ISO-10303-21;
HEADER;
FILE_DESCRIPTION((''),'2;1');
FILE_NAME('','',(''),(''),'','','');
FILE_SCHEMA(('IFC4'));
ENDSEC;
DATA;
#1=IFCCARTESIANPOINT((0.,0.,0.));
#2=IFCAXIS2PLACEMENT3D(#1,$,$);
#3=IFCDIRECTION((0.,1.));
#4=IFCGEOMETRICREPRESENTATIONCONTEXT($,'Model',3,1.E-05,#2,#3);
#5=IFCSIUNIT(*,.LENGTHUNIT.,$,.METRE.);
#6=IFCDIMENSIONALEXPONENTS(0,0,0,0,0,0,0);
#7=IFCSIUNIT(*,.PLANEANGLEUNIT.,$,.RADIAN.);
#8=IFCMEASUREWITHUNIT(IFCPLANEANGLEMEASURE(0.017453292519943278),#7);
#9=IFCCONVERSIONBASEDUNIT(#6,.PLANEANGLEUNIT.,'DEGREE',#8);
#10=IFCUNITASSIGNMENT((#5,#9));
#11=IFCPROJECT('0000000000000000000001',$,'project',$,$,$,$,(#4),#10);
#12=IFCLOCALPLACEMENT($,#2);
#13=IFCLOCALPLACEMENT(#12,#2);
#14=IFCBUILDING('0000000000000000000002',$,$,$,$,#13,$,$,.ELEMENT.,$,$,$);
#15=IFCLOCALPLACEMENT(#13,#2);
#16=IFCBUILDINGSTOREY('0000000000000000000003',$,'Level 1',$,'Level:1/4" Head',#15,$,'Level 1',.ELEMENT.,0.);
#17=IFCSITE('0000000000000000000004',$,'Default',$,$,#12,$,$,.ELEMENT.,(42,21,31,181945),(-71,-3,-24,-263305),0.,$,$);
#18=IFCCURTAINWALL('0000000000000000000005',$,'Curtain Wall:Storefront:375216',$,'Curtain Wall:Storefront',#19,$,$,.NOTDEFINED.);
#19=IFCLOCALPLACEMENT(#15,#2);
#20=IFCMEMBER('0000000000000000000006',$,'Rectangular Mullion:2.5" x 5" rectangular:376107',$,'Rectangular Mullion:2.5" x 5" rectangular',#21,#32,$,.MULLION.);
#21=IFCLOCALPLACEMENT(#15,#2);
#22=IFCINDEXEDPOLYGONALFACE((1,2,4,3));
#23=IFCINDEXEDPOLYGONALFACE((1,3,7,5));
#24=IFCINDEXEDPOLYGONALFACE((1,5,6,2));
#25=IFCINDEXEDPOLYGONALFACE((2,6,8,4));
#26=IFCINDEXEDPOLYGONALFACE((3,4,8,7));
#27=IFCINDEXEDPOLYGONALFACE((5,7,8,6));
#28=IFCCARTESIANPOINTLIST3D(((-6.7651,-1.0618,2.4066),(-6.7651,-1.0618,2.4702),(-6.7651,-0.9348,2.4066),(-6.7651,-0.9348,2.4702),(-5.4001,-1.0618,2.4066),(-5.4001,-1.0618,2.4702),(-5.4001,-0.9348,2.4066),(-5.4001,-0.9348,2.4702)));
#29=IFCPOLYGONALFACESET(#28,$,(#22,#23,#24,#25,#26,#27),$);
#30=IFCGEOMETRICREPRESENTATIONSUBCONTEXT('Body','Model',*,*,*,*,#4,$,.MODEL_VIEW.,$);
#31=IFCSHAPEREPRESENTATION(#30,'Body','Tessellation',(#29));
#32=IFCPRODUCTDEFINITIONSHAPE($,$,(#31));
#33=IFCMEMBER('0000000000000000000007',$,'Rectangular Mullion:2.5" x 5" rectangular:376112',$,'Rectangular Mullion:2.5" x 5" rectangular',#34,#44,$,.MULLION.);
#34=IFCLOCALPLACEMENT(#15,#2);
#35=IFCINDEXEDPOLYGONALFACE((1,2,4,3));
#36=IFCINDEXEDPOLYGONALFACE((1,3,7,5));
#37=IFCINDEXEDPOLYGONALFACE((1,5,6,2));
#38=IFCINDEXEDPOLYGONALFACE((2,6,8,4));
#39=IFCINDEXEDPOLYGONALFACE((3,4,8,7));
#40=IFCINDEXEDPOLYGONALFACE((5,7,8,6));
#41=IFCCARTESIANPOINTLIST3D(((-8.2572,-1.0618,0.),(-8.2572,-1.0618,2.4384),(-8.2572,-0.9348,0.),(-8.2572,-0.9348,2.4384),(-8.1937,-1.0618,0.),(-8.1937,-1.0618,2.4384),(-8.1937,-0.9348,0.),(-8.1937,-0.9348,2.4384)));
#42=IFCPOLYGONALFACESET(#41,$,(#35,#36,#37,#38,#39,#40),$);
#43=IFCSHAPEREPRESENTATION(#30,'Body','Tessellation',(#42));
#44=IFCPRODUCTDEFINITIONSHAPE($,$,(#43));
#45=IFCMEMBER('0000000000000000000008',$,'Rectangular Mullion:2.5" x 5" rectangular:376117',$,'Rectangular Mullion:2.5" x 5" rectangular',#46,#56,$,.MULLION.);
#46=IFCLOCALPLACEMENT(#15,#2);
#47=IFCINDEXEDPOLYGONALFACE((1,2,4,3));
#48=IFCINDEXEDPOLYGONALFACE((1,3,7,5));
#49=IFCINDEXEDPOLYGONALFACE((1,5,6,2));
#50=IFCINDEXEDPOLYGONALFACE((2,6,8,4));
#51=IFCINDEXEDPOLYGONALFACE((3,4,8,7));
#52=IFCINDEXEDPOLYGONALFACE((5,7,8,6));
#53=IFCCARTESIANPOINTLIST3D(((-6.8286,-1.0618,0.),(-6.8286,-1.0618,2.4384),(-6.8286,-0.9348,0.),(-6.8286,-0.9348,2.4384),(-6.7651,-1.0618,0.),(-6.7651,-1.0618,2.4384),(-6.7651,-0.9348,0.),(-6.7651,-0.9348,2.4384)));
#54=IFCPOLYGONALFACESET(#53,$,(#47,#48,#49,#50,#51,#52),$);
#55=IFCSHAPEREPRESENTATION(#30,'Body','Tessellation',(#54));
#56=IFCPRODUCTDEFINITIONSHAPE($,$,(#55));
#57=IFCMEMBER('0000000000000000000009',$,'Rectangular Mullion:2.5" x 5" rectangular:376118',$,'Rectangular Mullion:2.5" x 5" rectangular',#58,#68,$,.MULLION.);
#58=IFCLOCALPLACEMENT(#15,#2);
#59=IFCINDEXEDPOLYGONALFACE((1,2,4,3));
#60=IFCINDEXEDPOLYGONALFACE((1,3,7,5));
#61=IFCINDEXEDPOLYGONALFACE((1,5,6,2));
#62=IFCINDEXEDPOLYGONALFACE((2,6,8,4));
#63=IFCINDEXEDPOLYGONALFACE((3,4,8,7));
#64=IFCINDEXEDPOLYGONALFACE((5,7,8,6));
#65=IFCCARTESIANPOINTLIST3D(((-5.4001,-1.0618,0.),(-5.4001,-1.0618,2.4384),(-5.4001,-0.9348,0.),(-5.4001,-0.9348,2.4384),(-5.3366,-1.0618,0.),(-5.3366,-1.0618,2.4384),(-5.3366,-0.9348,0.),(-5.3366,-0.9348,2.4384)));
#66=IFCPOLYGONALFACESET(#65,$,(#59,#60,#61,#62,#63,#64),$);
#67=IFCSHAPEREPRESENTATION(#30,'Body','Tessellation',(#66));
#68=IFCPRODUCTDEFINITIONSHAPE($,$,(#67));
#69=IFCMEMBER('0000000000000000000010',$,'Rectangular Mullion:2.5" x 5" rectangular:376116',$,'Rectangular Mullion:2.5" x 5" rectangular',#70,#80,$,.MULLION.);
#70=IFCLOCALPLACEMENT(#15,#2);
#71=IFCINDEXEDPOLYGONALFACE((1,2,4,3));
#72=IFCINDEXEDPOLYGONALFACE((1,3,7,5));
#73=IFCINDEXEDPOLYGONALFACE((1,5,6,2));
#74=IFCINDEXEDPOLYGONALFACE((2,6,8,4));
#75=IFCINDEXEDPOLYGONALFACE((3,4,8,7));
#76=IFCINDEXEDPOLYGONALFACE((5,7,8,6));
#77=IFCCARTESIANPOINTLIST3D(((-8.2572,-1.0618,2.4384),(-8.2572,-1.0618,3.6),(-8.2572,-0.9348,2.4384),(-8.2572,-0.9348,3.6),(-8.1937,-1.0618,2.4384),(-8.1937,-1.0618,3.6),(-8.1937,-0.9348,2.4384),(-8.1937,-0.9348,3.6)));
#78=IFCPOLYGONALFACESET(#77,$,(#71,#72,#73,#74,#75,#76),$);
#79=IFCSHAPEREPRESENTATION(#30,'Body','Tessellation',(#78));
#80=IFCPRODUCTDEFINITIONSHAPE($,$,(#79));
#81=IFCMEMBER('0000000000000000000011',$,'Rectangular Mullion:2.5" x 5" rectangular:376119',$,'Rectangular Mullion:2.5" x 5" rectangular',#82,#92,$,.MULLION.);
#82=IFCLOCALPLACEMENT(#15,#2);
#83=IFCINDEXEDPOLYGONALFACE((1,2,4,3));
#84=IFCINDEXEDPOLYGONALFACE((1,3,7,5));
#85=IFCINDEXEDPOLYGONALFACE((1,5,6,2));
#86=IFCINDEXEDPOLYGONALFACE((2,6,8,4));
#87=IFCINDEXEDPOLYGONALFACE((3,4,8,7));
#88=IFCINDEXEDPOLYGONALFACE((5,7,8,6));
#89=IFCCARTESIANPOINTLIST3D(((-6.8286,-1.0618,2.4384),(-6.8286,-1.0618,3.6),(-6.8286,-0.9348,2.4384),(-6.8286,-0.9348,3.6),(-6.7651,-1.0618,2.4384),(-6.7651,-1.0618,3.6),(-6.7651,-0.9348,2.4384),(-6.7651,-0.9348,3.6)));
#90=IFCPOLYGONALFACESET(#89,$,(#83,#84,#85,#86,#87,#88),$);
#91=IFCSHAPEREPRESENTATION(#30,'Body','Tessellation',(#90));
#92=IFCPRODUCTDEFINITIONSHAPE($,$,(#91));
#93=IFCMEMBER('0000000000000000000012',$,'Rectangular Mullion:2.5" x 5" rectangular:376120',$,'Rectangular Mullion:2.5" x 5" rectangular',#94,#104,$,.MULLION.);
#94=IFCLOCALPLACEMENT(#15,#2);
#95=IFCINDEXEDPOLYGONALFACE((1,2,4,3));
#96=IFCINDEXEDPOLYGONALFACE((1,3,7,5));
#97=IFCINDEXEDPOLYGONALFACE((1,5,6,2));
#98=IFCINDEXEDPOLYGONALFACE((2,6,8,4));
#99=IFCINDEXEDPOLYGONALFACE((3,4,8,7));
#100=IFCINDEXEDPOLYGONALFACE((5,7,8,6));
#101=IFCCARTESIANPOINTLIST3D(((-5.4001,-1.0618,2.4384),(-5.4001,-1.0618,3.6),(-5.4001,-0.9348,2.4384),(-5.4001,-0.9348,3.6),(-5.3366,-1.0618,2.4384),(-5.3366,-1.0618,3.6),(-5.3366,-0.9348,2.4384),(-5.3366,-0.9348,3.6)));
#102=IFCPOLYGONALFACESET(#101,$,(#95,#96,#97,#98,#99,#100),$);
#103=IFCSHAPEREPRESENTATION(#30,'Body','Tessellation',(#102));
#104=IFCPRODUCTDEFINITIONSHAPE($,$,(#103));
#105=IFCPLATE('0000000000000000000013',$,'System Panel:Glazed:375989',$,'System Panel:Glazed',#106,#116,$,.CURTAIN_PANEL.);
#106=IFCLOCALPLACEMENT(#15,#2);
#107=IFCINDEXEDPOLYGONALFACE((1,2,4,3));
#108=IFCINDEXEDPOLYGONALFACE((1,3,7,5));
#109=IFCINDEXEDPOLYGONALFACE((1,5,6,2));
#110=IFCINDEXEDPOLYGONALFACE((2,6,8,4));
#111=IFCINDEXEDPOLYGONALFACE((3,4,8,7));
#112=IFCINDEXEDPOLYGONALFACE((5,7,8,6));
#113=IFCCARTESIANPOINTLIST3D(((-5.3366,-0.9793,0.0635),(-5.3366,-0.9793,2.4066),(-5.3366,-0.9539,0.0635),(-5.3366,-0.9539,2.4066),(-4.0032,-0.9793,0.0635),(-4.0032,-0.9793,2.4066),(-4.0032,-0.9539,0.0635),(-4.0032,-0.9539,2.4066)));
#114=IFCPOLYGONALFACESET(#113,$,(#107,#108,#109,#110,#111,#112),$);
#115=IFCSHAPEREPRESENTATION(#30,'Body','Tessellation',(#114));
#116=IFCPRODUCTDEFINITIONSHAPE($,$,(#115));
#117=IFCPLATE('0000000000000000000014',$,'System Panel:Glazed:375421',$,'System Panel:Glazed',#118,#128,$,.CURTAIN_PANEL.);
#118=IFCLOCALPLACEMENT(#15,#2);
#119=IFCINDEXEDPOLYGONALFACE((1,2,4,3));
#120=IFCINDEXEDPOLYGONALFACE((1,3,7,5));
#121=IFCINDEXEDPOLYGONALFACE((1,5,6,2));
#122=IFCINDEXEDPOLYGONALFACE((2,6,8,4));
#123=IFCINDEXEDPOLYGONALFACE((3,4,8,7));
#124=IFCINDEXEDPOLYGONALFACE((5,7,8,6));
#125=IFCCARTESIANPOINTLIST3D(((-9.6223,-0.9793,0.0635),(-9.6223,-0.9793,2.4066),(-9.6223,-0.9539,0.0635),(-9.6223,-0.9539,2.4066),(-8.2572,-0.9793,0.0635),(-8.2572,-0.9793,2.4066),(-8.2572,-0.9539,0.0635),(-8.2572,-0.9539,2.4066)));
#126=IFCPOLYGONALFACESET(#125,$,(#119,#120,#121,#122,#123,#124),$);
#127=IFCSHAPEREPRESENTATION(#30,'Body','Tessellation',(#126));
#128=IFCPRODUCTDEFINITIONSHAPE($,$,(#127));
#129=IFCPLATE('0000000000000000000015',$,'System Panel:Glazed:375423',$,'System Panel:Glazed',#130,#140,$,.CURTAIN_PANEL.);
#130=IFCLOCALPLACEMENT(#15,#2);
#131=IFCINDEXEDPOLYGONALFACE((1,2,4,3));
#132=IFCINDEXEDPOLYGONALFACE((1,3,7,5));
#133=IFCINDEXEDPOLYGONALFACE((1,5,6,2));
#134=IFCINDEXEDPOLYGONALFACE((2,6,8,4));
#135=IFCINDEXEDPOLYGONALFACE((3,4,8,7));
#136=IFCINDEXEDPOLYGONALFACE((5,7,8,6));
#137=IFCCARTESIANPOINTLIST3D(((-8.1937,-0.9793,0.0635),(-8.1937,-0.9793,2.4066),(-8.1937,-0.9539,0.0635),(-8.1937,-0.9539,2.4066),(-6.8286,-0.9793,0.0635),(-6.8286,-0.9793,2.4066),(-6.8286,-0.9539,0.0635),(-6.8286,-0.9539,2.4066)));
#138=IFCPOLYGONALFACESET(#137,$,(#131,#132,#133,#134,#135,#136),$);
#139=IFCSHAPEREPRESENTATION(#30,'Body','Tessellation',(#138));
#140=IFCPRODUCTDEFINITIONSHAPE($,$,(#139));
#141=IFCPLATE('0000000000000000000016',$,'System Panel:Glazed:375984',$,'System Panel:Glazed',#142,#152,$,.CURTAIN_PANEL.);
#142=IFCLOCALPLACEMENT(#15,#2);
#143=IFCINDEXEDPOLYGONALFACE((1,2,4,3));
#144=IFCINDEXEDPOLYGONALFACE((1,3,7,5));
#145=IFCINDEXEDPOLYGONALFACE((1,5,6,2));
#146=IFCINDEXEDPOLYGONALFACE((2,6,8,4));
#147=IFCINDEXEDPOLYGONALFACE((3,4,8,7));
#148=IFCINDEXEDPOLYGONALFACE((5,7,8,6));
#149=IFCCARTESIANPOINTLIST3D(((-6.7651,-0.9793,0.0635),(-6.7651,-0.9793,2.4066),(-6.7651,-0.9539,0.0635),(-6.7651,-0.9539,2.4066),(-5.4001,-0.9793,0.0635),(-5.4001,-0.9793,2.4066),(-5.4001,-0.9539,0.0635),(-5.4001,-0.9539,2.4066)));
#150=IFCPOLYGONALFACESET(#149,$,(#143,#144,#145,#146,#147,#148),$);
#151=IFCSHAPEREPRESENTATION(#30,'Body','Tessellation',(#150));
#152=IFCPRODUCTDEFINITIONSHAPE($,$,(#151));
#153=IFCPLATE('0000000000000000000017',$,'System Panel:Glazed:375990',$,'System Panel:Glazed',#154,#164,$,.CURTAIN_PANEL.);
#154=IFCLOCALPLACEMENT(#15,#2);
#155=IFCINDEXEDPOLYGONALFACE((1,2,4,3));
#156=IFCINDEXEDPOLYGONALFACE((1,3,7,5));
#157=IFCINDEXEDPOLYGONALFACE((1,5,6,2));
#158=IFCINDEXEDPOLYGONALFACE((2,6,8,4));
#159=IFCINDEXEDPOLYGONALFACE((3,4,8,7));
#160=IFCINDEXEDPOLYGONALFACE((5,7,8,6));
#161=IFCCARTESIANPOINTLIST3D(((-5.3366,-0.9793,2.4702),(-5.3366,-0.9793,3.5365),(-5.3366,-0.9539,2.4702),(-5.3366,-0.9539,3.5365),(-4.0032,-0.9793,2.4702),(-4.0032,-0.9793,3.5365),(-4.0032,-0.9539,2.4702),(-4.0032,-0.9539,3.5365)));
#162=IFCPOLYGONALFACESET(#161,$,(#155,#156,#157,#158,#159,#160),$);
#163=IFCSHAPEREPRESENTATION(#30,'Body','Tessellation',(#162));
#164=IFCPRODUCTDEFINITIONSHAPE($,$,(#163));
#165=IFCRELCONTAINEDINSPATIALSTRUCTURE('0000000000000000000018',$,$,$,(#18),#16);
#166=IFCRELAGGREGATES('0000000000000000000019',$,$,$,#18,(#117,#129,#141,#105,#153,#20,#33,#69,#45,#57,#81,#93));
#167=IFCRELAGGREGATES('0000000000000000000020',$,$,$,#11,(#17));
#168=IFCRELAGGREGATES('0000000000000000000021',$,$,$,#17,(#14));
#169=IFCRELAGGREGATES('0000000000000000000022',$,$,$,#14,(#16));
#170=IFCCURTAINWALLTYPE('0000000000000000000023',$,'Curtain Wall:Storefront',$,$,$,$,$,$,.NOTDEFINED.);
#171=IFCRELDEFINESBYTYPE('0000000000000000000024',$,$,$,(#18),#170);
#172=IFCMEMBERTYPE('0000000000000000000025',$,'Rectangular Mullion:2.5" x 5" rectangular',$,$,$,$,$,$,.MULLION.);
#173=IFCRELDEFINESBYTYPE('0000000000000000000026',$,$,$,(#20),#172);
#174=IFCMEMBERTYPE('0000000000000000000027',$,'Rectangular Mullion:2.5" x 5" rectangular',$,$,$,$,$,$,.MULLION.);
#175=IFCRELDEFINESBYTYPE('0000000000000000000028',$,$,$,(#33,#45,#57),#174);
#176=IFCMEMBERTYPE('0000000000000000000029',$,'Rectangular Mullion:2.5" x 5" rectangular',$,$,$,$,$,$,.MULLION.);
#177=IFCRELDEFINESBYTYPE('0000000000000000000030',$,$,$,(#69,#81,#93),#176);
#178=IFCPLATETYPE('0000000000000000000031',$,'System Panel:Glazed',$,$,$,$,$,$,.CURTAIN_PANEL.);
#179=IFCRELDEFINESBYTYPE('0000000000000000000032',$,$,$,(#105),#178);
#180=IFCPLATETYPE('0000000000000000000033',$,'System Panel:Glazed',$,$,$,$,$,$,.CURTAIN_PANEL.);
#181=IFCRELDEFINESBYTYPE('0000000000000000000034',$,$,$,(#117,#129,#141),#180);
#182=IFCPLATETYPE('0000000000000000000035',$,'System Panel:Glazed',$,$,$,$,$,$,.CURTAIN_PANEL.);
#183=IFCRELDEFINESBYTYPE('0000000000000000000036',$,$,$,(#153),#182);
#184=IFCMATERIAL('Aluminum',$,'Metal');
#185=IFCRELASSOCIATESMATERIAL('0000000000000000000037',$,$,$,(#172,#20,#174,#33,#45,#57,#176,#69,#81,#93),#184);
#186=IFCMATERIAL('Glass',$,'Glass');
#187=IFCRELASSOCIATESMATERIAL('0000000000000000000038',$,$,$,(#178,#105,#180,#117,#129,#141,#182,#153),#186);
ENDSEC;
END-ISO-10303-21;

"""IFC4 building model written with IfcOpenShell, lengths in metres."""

from ifc_helpers import new_model, entity, si_unit, converted_unit, direction, frame, origin, place, context, subcontext, project, spatial, indexed_curve, outline, extrude, source, transform, mapped, material, type_object, type_shapes, element, aggregate, save


model = new_model("IFC4")

# Units and contexts
model_context = context("Model", 3, precision=1e-05, world=origin(), true_north=direction((0.0, 1.0)))
body_context = subcontext(model_context, "Body", "Model", "MODEL_VIEW")
ifc_project = project(units=[si_unit("LENGTHUNIT", "METRE"), converted_unit("PLANEANGLEUNIT", "DEGREE", entity("IfcPlaneAngleMeasure", 0.017453292519943278), si_unit("PLANEANGLEUNIT", "RADIAN"), dimensions=[0, 0, 0, 0, 0, 0, 0])], contexts=[model_context])

# Site, building, storey
site_placement = place(None, origin())
site = spatial("IfcSite", under=ifc_project, at=site_placement, Name="Default", CompositionType="ELEMENT", RefLatitude=(42, 21, 31, 181945), RefLongitude=(-71, -3, -24, -263305), RefElevation=0.0)
building_placement = place(site_placement, origin())
building = spatial("IfcBuilding", under=site, at=building_placement, CompositionType="ELEMENT")
storey_placement = place(building_placement, origin())
storey = spatial("IfcBuildingStorey", under=building, at=storey_placement, Name="Level 1", ObjectType="Level:1/4\" Head", LongName="Level 1", CompositionType="ELEMENT", Elevation=0.0)

# Curtain wall, members, plates
curtain_wall_type = type_object("IfcCurtainWallType", Name="Curtain Wall:Storefront", PredefinedType="NOTDEFINED")
curtain_wall_placement = place(storey_placement, origin())
curtain_wall = element("IfcCurtainWall", 1, at=curtain_wall_placement, inside=storey, type_object=curtain_wall_type, Name="Curtain Wall:Storefront:375216", ObjectType="Curtain Wall:Storefront", PredefinedType="NOTDEFINED")
ifc_material_1 = material(Name="Aluminum", Category="Metal")
member_type_1 = type_object("IfcMemberType", Name="Rectangular Mullion:2.5\" x 5\" rectangular", PredefinedType="MULLION", material=ifc_material_1)
shared_shape_1 = source(origin(), body_context, "Body", "SweptSolid", [
    extrude(outline(indexed_curve([(-0.0318, -0.0635), (0.0318, -0.0635), (0.0318, 0.0635), (-0.0318, 0.0635), (-0.0318, -0.0635)], self_intersect=False)), frame((0.0, 0.0, -1.3651), z_axis=(0.0, 0.0, 1.0), x_axis=(-1.0, 0.0, 0.0)), (0.0, 0.0, 1.0), 1.3651),
])
type_shapes(member_type_1, [shared_shape_1])
member_1_placement = place(curtain_wall_placement, frame((-5.4001, -0.9983, 2.4384), z_axis=(1.0, 0.0, 0.0), x_axis=(0.0, 0.0, 1.0)))
member_1 = element("IfcMember", 2, at=member_1_placement, type_object=member_type_1, material=ifc_material_1, Name="Rectangular Mullion:2.5\" x 5\" rectangular:376107", ObjectType="Rectangular Mullion:2.5\" x 5\" rectangular", PredefinedType="MULLION", context=body_context, shape_type="MappedRepresentation", body=[
    mapped(shared_shape_1, transform((0.0, 0.0, 0.0), scale=1.0)),
])
member_type_2 = type_object("IfcMemberType", Name="Rectangular Mullion:2.5\" x 5\" rectangular", PredefinedType="MULLION", material=ifc_material_1)
shared_shape_2 = source(origin(), body_context, "Body", "SweptSolid", [
    extrude(outline(indexed_curve([(-0.0318, -0.0635), (0.0318, -0.0635), (0.0318, 0.0635), (-0.0318, 0.0635), (-0.0318, -0.0635)], self_intersect=False)), frame((0.0, 0.0, -2.4384), z_axis=(0.0, 0.0, 1.0), x_axis=(-1.0, 0.0, 0.0)), (0.0, 0.0, 1.0), 2.4384),
])
type_shapes(member_type_2, [shared_shape_2])
member_2_placement = place(curtain_wall_placement, frame((-8.2254, -0.9983, 0.0), z_axis=(0.0, 0.0, -1.0), x_axis=(1.0, 0.0, 0.0)))
member_2 = element("IfcMember", 3, at=member_2_placement, type_object=member_type_2, material=ifc_material_1, Name="Rectangular Mullion:2.5\" x 5\" rectangular:376112", ObjectType="Rectangular Mullion:2.5\" x 5\" rectangular", PredefinedType="MULLION", context=body_context, shape_type="MappedRepresentation", body=[
    mapped(shared_shape_2, transform((0.0, 0.0, 0.0), scale=1.0)),
])
member_3_placement = place(curtain_wall_placement, frame((-6.7969, -0.9983, 0.0), z_axis=(0.0, 0.0, -1.0), x_axis=(1.0, 0.0, 0.0)))
member_3 = element("IfcMember", 4, at=member_3_placement, type_object=member_type_2, material=ifc_material_1, Name="Rectangular Mullion:2.5\" x 5\" rectangular:376117", ObjectType="Rectangular Mullion:2.5\" x 5\" rectangular", PredefinedType="MULLION", context=body_context, shape_type="MappedRepresentation", body=[
    mapped(shared_shape_2, transform((0.0, 0.0, 0.0), scale=1.0)),
])
member_4_placement = place(curtain_wall_placement, frame((-5.3683, -0.9983, 0.0), z_axis=(0.0, 0.0, -1.0), x_axis=(1.0, 0.0, 0.0)))
member_4 = element("IfcMember", 5, at=member_4_placement, type_object=member_type_2, material=ifc_material_1, Name="Rectangular Mullion:2.5\" x 5\" rectangular:376118", ObjectType="Rectangular Mullion:2.5\" x 5\" rectangular", PredefinedType="MULLION", context=body_context, shape_type="MappedRepresentation", body=[
    mapped(shared_shape_2, transform((0.0, 0.0, 0.0), scale=1.0)),
])
member_type_3 = type_object("IfcMemberType", Name="Rectangular Mullion:2.5\" x 5\" rectangular", PredefinedType="MULLION", material=ifc_material_1)
shared_shape_3 = source(origin(), body_context, "Body", "SweptSolid", [
    extrude(outline(indexed_curve([(-0.0318, -0.0635), (0.0318, -0.0635), (0.0318, 0.0635), (-0.0318, 0.0635), (-0.0318, -0.0635)], self_intersect=False)), frame((0.0, 0.0, -1.1616), z_axis=(0.0, 0.0, 1.0), x_axis=(-1.0, 0.0, 0.0)), (0.0, 0.0, 1.0), 1.1616),
])
type_shapes(member_type_3, [shared_shape_3])
member_5_placement = place(curtain_wall_placement, frame((-8.2254, -0.9983, 2.4384), z_axis=(0.0, 0.0, -1.0), x_axis=(1.0, 0.0, 0.0)))
member_5 = element("IfcMember", 6, at=member_5_placement, type_object=member_type_3, material=ifc_material_1, Name="Rectangular Mullion:2.5\" x 5\" rectangular:376116", ObjectType="Rectangular Mullion:2.5\" x 5\" rectangular", PredefinedType="MULLION", context=body_context, shape_type="MappedRepresentation", body=[
    mapped(shared_shape_3, transform((0.0, 0.0, 0.0), scale=1.0)),
])
member_6_placement = place(curtain_wall_placement, frame((-6.7969, -0.9983, 2.4384), z_axis=(0.0, 0.0, -1.0), x_axis=(1.0, 0.0, 0.0)))
member_6 = element("IfcMember", 7, at=member_6_placement, type_object=member_type_3, material=ifc_material_1, Name="Rectangular Mullion:2.5\" x 5\" rectangular:376119", ObjectType="Rectangular Mullion:2.5\" x 5\" rectangular", PredefinedType="MULLION", context=body_context, shape_type="MappedRepresentation", body=[
    mapped(shared_shape_3, transform((0.0, 0.0, 0.0), scale=1.0)),
])
member_7_placement = place(curtain_wall_placement, frame((-5.3683, -0.9983, 2.4384), z_axis=(0.0, 0.0, -1.0), x_axis=(1.0, 0.0, 0.0)))
member_7 = element("IfcMember", 8, at=member_7_placement, type_object=member_type_3, material=ifc_material_1, Name="Rectangular Mullion:2.5\" x 5\" rectangular:376120", ObjectType="Rectangular Mullion:2.5\" x 5\" rectangular", PredefinedType="MULLION", context=body_context, shape_type="MappedRepresentation", body=[
    mapped(shared_shape_3, transform((0.0, 0.0, 0.0), scale=1.0)),
])
ifc_material_2 = material(Name="Glass", Category="Glass")
plate_type_1 = type_object("IfcPlateType", Name="System Panel:Glazed", PredefinedType="CURTAIN_PANEL", material=ifc_material_2)
shared_shape_4 = source(origin(), body_context, "Body", "SweptSolid", [
    extrude(outline(indexed_curve([(-0.0127, -0.6667), (0.0127, -0.6667), (0.0127, 0.6667), (-0.0127, 0.6667), (-0.0127, -0.6667)], self_intersect=False)), frame((0.0, 0.0318, 0.0), z_axis=(0.0, 0.0, 1.0), x_axis=(0.0, 1.0, 0.0)), (0.0, 0.0, 1.0), 2.3432),
])
type_shapes(plate_type_1, [shared_shape_4])
plate_1_placement = place(curtain_wall_placement, frame((-4.6699, -0.9983, 0.0635)))
plate_1 = element("IfcPlate", 9, at=plate_1_placement, type_object=plate_type_1, material=ifc_material_2, Name="System Panel:Glazed:375989", ObjectType="System Panel:Glazed", PredefinedType="CURTAIN_PANEL", context=body_context, shape_type="MappedRepresentation", body=[
    mapped(shared_shape_4, transform((0.0, 0.0, 0.0), scale=1.0)),
])
plate_type_2 = type_object("IfcPlateType", Name="System Panel:Glazed", PredefinedType="CURTAIN_PANEL", material=ifc_material_2)
shared_shape_5 = source(origin(), body_context, "Body", "SweptSolid", [
    extrude(outline(indexed_curve([(-0.0127, -0.6825), (0.0127, -0.6825), (0.0127, 0.6825), (-0.0127, 0.6825), (-0.0127, -0.6825)], self_intersect=False)), frame((0.0, 0.0318, 0.0), z_axis=(0.0, 0.0, 1.0), x_axis=(0.0, 1.0, 0.0)), (0.0, 0.0, 1.0), 2.3432),
])
type_shapes(plate_type_2, [shared_shape_5])
plate_2_placement = place(curtain_wall_placement, frame((-8.9397, -0.9983, 0.0635)))
plate_2 = element("IfcPlate", 10, at=plate_2_placement, type_object=plate_type_2, material=ifc_material_2, Name="System Panel:Glazed:375421", ObjectType="System Panel:Glazed", PredefinedType="CURTAIN_PANEL", context=body_context, shape_type="MappedRepresentation", body=[
    mapped(shared_shape_5, transform((0.0, 0.0, 0.0), scale=1.0)),
])
plate_3_placement = place(curtain_wall_placement, frame((-7.5112, -0.9983, 0.0635)))
plate_3 = element("IfcPlate", 11, at=plate_3_placement, type_object=plate_type_2, material=ifc_material_2, Name="System Panel:Glazed:375423", ObjectType="System Panel:Glazed", PredefinedType="CURTAIN_PANEL", context=body_context, shape_type="MappedRepresentation", body=[
    mapped(shared_shape_5, transform((0.0, 0.0, 0.0), scale=1.0)),
])
plate_4_placement = place(curtain_wall_placement, frame((-6.0826, -0.9983, 0.0635)))
plate_4 = element("IfcPlate", 12, at=plate_4_placement, type_object=plate_type_2, material=ifc_material_2, Name="System Panel:Glazed:375984", ObjectType="System Panel:Glazed", PredefinedType="CURTAIN_PANEL", context=body_context, shape_type="MappedRepresentation", body=[
    mapped(shared_shape_5, transform((0.0, 0.0, 0.0), scale=1.0)),
])
plate_type_3 = type_object("IfcPlateType", Name="System Panel:Glazed", PredefinedType="CURTAIN_PANEL", material=ifc_material_2)
shared_shape_6 = source(origin(), body_context, "Body", "SweptSolid", [
    extrude(outline(indexed_curve([(-0.0127, -0.6667), (0.0127, -0.6667), (0.0127, 0.6667), (-0.0127, 0.6667), (-0.0127, -0.6667)], self_intersect=False)), frame((0.0, 0.0318, 0.0), z_axis=(0.0, 0.0, 1.0), x_axis=(0.0, 1.0, 0.0)), (0.0, 0.0, 1.0), 1.0663),
])
type_shapes(plate_type_3, [shared_shape_6])
plate_5_placement = place(curtain_wall_placement, frame((-4.6699, -0.9983, 2.4701)))
plate_5 = element("IfcPlate", 13, at=plate_5_placement, type_object=plate_type_3, material=ifc_material_2, Name="System Panel:Glazed:375990", ObjectType="System Panel:Glazed", PredefinedType="CURTAIN_PANEL", context=body_context, shape_type="MappedRepresentation", body=[
    mapped(shared_shape_6, transform((0.0, 0.0, 0.0), scale=1.0)),
])
aggregate(curtain_wall, [plate_2, plate_3, plate_4, plate_1, plate_5, member_1, member_2, member_5, member_3, member_4, member_6, member_7])

save(model, "model.ifc")
